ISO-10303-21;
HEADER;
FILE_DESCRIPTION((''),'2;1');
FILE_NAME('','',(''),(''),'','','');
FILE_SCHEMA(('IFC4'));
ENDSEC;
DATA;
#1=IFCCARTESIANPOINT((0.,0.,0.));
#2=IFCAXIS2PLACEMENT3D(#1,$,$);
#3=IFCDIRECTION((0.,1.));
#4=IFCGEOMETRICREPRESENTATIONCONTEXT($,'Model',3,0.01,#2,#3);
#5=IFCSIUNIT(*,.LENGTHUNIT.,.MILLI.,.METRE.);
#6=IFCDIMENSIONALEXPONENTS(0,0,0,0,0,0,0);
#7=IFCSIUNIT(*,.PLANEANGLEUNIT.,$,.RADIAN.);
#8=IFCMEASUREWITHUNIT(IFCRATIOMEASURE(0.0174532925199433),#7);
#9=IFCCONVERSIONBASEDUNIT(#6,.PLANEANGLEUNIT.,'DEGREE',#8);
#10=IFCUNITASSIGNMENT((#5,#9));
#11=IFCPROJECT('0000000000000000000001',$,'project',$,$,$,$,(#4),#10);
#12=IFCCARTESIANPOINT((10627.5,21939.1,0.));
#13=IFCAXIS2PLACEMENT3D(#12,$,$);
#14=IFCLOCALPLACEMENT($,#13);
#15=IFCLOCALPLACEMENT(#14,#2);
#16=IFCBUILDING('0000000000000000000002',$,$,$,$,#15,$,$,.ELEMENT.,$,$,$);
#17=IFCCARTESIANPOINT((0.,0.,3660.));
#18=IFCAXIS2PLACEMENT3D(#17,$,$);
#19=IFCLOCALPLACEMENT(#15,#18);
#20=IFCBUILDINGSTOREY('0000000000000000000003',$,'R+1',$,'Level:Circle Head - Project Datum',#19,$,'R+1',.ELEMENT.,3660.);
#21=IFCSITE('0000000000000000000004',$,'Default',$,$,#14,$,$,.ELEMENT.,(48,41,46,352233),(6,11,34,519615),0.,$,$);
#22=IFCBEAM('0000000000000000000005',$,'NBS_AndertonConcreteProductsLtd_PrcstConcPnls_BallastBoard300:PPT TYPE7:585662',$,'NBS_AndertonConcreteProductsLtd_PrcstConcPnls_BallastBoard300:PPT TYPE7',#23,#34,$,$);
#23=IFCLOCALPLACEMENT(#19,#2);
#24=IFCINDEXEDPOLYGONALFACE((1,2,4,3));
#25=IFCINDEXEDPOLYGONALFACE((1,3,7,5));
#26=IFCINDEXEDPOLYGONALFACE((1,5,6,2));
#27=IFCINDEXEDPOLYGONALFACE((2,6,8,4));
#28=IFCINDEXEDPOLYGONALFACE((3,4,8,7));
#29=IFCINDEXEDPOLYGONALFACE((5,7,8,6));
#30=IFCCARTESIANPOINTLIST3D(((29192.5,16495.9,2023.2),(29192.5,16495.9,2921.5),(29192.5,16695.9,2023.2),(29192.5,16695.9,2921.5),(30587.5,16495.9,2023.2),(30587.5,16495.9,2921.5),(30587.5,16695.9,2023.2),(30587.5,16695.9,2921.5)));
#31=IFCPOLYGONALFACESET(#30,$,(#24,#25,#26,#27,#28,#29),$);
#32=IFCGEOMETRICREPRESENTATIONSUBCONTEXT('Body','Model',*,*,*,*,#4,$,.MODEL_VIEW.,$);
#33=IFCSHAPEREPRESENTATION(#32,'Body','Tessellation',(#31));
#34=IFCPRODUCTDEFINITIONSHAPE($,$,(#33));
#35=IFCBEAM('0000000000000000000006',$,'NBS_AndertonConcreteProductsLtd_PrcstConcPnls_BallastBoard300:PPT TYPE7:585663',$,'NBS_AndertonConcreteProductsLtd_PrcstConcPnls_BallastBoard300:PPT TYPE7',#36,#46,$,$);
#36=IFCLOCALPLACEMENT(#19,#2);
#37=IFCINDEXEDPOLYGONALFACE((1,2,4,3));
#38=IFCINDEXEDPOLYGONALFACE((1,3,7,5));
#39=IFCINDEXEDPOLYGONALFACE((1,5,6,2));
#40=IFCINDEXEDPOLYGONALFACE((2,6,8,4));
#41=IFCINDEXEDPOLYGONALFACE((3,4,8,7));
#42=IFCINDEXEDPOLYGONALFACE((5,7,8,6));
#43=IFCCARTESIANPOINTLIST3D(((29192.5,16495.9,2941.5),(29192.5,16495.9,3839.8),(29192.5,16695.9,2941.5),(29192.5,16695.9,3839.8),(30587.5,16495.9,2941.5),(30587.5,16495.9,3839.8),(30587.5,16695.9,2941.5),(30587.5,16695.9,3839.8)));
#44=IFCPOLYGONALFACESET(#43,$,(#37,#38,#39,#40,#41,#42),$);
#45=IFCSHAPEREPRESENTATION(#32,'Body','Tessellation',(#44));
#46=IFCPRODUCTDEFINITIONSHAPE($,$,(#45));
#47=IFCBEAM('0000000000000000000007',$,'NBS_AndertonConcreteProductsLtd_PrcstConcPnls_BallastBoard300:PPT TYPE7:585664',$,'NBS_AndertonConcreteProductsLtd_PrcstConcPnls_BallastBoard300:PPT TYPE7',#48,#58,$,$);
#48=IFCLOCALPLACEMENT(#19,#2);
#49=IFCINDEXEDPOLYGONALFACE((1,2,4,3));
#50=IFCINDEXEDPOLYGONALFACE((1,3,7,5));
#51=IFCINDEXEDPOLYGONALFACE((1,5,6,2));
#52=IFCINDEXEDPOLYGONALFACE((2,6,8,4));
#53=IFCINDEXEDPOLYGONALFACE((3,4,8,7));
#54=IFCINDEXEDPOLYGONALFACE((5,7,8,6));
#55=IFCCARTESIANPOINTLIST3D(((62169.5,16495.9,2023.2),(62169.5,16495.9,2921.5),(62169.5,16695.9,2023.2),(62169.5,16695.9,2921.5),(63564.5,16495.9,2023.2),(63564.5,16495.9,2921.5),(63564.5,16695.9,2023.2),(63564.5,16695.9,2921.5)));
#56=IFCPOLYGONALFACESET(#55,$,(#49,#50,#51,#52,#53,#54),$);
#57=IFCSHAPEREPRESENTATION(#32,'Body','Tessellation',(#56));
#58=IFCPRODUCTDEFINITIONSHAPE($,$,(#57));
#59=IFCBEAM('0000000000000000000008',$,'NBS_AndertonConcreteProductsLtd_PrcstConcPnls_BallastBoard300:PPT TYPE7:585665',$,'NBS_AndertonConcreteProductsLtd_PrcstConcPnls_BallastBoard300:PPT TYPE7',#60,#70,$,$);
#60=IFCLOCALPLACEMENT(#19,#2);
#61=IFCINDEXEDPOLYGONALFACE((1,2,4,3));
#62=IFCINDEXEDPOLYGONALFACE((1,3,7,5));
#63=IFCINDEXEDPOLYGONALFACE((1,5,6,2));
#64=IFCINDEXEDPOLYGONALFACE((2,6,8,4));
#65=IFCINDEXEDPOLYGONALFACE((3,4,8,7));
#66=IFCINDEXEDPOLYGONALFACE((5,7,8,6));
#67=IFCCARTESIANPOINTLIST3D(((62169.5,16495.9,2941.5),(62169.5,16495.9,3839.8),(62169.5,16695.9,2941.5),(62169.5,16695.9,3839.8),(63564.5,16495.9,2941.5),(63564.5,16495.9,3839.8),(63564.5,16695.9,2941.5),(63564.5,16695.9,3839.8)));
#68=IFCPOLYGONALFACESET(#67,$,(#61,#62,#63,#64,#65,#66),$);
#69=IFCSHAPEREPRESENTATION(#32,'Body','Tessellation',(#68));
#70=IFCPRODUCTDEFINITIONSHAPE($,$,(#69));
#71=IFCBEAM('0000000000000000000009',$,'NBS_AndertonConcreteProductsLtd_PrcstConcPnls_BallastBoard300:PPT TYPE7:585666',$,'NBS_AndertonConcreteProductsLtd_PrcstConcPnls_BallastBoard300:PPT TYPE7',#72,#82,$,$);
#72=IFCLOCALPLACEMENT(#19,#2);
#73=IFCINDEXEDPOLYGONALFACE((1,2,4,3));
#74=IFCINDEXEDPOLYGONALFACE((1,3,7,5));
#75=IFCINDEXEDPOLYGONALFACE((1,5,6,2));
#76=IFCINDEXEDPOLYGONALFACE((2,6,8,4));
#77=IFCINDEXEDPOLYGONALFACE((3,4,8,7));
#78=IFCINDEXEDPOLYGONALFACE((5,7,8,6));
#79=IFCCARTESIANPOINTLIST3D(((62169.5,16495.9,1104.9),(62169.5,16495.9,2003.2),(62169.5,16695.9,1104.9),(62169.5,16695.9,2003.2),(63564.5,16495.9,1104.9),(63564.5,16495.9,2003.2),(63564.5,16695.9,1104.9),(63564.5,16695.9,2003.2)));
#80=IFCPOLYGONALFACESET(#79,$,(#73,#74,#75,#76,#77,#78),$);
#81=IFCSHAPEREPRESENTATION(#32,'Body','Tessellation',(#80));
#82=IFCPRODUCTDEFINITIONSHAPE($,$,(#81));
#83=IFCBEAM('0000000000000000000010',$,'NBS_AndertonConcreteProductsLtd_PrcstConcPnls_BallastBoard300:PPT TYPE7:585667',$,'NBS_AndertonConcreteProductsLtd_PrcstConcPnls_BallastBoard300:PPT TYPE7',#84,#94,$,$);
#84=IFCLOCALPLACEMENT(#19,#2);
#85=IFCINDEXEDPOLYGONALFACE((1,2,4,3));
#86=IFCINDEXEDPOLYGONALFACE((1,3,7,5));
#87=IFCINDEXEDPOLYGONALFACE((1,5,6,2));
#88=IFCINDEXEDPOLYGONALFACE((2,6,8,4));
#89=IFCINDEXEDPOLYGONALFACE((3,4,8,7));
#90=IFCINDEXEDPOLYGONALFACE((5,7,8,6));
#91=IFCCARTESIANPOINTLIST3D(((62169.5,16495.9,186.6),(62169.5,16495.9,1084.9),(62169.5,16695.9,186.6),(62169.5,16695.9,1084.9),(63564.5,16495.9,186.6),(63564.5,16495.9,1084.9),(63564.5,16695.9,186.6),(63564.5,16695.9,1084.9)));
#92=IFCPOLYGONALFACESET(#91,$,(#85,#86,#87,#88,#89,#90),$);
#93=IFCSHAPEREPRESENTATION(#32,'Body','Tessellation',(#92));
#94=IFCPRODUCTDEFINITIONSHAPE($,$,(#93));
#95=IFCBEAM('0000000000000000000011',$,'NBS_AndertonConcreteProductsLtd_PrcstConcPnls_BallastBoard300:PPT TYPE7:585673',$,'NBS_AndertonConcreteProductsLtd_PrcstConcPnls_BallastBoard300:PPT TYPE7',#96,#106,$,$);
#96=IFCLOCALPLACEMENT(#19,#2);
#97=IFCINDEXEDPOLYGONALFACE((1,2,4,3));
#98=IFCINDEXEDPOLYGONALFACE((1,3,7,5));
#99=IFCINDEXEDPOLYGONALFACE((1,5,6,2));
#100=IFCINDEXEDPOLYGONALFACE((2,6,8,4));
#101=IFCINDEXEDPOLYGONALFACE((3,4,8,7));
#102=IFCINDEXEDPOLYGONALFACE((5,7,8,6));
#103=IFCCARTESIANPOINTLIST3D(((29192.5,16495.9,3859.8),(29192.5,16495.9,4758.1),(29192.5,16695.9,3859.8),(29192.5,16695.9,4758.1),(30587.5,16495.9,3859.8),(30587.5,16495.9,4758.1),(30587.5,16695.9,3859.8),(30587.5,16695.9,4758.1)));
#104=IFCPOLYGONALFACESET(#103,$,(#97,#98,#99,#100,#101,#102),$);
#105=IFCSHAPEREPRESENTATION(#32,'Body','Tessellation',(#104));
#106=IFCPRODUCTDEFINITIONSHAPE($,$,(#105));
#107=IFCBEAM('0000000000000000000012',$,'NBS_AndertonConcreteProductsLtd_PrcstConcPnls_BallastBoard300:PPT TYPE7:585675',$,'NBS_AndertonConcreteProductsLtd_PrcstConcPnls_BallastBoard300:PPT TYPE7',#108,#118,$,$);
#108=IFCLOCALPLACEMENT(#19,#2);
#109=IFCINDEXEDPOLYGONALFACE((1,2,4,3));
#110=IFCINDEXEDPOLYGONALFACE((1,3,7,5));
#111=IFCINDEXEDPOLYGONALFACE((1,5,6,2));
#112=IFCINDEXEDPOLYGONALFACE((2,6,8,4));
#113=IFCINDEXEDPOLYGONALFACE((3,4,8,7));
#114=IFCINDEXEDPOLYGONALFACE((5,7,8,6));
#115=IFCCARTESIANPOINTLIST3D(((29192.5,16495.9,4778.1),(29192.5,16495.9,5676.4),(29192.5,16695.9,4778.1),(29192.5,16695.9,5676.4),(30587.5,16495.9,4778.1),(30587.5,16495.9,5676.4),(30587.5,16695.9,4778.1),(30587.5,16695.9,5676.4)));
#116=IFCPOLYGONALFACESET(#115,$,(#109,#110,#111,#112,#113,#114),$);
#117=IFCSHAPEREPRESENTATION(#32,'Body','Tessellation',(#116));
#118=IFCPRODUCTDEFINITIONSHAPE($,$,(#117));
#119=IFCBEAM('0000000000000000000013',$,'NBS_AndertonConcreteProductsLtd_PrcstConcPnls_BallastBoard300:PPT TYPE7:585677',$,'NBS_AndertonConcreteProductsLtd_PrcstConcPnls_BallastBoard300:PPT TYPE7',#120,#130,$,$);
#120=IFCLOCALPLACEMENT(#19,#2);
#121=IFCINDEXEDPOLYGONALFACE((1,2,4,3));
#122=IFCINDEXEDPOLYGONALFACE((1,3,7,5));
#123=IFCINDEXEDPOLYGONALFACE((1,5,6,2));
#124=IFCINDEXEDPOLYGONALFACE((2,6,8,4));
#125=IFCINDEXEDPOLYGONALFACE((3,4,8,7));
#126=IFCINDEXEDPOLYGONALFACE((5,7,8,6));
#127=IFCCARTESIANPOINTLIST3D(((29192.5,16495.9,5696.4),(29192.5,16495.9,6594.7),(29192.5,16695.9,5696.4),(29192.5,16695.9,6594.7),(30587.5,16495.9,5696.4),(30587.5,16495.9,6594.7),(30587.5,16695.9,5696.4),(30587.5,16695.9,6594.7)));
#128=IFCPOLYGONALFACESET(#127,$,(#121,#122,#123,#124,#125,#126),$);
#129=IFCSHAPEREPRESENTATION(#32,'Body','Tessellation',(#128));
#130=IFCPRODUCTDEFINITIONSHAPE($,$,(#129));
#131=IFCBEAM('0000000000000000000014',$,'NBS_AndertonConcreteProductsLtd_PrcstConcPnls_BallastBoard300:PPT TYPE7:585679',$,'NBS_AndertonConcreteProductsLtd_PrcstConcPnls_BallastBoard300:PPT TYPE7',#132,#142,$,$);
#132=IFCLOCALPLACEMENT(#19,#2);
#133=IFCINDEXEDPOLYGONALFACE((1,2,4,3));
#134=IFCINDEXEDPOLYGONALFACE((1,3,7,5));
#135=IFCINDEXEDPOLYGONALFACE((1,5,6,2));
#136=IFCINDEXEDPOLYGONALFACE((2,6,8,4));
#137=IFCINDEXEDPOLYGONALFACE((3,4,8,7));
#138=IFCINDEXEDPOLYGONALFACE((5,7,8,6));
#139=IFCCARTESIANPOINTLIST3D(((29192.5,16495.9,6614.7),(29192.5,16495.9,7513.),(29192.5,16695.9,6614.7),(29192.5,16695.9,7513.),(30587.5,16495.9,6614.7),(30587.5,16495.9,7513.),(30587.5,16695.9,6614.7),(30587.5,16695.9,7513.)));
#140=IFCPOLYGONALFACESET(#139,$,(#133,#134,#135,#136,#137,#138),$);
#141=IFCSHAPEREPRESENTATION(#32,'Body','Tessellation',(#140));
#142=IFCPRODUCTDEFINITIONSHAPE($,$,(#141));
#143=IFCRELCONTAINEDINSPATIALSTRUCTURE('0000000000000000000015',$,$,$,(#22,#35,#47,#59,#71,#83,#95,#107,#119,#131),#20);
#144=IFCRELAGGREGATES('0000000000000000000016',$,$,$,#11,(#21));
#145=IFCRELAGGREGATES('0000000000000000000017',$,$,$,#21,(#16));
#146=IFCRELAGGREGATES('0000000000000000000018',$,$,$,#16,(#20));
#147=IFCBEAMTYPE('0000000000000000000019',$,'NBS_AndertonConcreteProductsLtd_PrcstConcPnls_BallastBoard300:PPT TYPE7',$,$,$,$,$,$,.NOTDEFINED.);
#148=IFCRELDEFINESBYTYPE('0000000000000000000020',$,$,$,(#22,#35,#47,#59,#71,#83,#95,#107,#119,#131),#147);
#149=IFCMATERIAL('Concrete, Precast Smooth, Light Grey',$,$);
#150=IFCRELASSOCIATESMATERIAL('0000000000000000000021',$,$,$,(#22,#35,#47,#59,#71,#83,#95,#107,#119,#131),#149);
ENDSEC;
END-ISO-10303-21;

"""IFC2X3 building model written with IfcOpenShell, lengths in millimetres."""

from ifc_helpers import new_model, entity, si_unit, converted_unit, direction, frame, frame_2d, origin, place, context, subcontext, project, spatial, rectangle, extrude, material, type_object, element, save


model = new_model("IFC2X3")

# Units and contexts
model_context = context("Model", 3, precision=0.01, world=origin(), true_north=direction((0.0, 1.0)))
body_context = subcontext(model_context, "Body", "Model", "MODEL_VIEW")
ifc_project = project(units=[si_unit("LENGTHUNIT", "METRE", prefix="MILLI"), converted_unit("PLANEANGLEUNIT", "DEGREE", entity("IfcRatioMeasure", 0.0174532925199433), si_unit("PLANEANGLEUNIT", "RADIAN"), dimensions=[0, 0, 0, 0, 0, 0, 0])], contexts=[model_context])

# Site, building, storey
site_placement = place(None, frame((10627.5, 21939.1, 0.0)))
site = spatial("IfcSite", under=ifc_project, at=site_placement, Name="Default", CompositionType="ELEMENT", RefLatitude=(48, 41, 46, 352233), RefLongitude=(6, 11, 34, 519615), RefElevation=0.0)
building_placement = place(site_placement, origin())
building = spatial("IfcBuilding", under=site, at=building_placement, CompositionType="ELEMENT")
storey_placement = place(building_placement, frame((0.0, 0.0, 3660.0)))
storey = spatial("IfcBuildingStorey", under=building, at=storey_placement, Name="R+1", ObjectType="Level:Circle Head - Project Datum", LongName="R+1", CompositionType="ELEMENT", Elevation=3660.0)

# Shared definitions
ifc_material_1 = material(Name="Concrete, Precast Smooth, Light Grey")

# Beams
beam_type_1 = type_object("IfcBeamType", Name="NBS_AndertonConcreteProductsLtd_PrcstConcPnls_BallastBoard300:PPT TYPE7", PredefinedType="NOTDEFINED")
beam_1_placement = place(storey_placement, origin())
element("IfcBeam", 1, at=beam_1_placement, inside=storey, type_object=beam_type_1, material=ifc_material_1, Name="NBS_AndertonConcreteProductsLtd_PrcstConcPnls_BallastBoard300:PPT TYPE7:585662", ObjectType="NBS_AndertonConcreteProductsLtd_PrcstConcPnls_BallastBoard300:PPT TYPE7", context=body_context, shape_type="SweptSolid", body=[
    extrude(rectangle(XDim=898.3, YDim=200.0, at=frame_2d((0.0, 0.0), x_axis=(1.0, 0.0))), frame((29192.5, 16595.9, 2472.4), z_axis=(1.0, 0.0, 0.0), x_axis=(0.0, 0.0, -1.0)), (0.0, 0.0, 1.0), 1395.0),
])
beam_2_placement = place(storey_placement, origin())
element("IfcBeam", 2, at=beam_2_placement, inside=storey, type_object=beam_type_1, material=ifc_material_1, Name="NBS_AndertonConcreteProductsLtd_PrcstConcPnls_BallastBoard300:PPT TYPE7:585663", ObjectType="NBS_AndertonConcreteProductsLtd_PrcstConcPnls_BallastBoard300:PPT TYPE7", context=body_context, shape_type="SweptSolid", body=[
    extrude(rectangle(XDim=898.3, YDim=200.0, at=frame_2d((0.0, 0.0), x_axis=(1.0, 0.0))), frame((29192.5, 16595.9, 3390.7), z_axis=(1.0, 0.0, 0.0), x_axis=(0.0, 0.0, -1.0)), (0.0, 0.0, 1.0), 1395.0),
])
beam_3_placement = place(storey_placement, origin())
element("IfcBeam", 3, at=beam_3_placement, inside=storey, type_object=beam_type_1, material=ifc_material_1, Name="NBS_AndertonConcreteProductsLtd_PrcstConcPnls_BallastBoard300:PPT TYPE7:585664", ObjectType="NBS_AndertonConcreteProductsLtd_PrcstConcPnls_BallastBoard300:PPT TYPE7", context=body_context, shape_type="SweptSolid", body=[
    extrude(rectangle(XDim=898.3, YDim=200.0, at=frame_2d((0.0, 0.0), x_axis=(1.0, 0.0))), frame((62169.5, 16595.9, 2472.4), z_axis=(1.0, 0.0, 0.0), x_axis=(0.0, 0.0, -1.0)), (0.0, 0.0, 1.0), 1395.0),
])
beam_4_placement = place(storey_placement, origin())
element("IfcBeam", 4, at=beam_4_placement, inside=storey, type_object=beam_type_1, material=ifc_material_1, Name="NBS_AndertonConcreteProductsLtd_PrcstConcPnls_BallastBoard300:PPT TYPE7:585665", ObjectType="NBS_AndertonConcreteProductsLtd_PrcstConcPnls_BallastBoard300:PPT TYPE7", context=body_context, shape_type="SweptSolid", body=[
    extrude(rectangle(XDim=898.3, YDim=200.0, at=frame_2d((0.0, 0.0), x_axis=(1.0, 0.0))), frame((62169.5, 16595.9, 3390.7), z_axis=(1.0, 0.0, 0.0), x_axis=(0.0, 0.0, -1.0)), (0.0, 0.0, 1.0), 1395.0),
])
beam_5_placement = place(storey_placement, origin())
element("IfcBeam", 5, at=beam_5_placement, inside=storey, type_object=beam_type_1, material=ifc_material_1, Name="NBS_AndertonConcreteProductsLtd_PrcstConcPnls_BallastBoard300:PPT TYPE7:585666", ObjectType="NBS_AndertonConcreteProductsLtd_PrcstConcPnls_BallastBoard300:PPT TYPE7", context=body_context, shape_type="SweptSolid", body=[
    extrude(rectangle(XDim=898.3, YDim=200.0, at=frame_2d((0.0, 0.0), x_axis=(1.0, 0.0))), frame((62169.5, 16595.9, 1554.0), z_axis=(1.0, 0.0, 0.0), x_axis=(0.0, 0.0, -1.0)), (0.0, 0.0, 1.0), 1395.0),
])
beam_6_placement = place(storey_placement, origin())
element("IfcBeam", 6, at=beam_6_placement, inside=storey, type_object=beam_type_1, material=ifc_material_1, Name="NBS_AndertonConcreteProductsLtd_PrcstConcPnls_BallastBoard300:PPT TYPE7:585667", ObjectType="NBS_AndertonConcreteProductsLtd_PrcstConcPnls_BallastBoard300:PPT TYPE7", context=body_context, shape_type="SweptSolid", body=[
    extrude(rectangle(XDim=898.3, YDim=200.0, at=frame_2d((0.0, 0.0), x_axis=(1.0, 0.0))), frame((62169.5, 16595.9, 635.7), z_axis=(1.0, 0.0, 0.0), x_axis=(0.0, 0.0, -1.0)), (0.0, 0.0, 1.0), 1395.0),
])
beam_7_placement = place(storey_placement, origin())
element("IfcBeam", 7, at=beam_7_placement, inside=storey, type_object=beam_type_1, material=ifc_material_1, Name="NBS_AndertonConcreteProductsLtd_PrcstConcPnls_BallastBoard300:PPT TYPE7:585673", ObjectType="NBS_AndertonConcreteProductsLtd_PrcstConcPnls_BallastBoard300:PPT TYPE7", context=body_context, shape_type="SweptSolid", body=[
    extrude(rectangle(XDim=898.3, YDim=200.0, at=frame_2d((0.0, 0.0), x_axis=(1.0, 0.0))), frame((29192.5, 16595.9, 4309.0), z_axis=(1.0, 0.0, 0.0), x_axis=(0.0, 0.0, -1.0)), (0.0, 0.0, 1.0), 1395.0),
])
beam_8_placement = place(storey_placement, origin())
element("IfcBeam", 8, at=beam_8_placement, inside=storey, type_object=beam_type_1, material=ifc_material_1, Name="NBS_AndertonConcreteProductsLtd_PrcstConcPnls_BallastBoard300:PPT TYPE7:585675", ObjectType="NBS_AndertonConcreteProductsLtd_PrcstConcPnls_BallastBoard300:PPT TYPE7", context=body_context, shape_type="SweptSolid", body=[
    extrude(rectangle(XDim=898.3, YDim=200.0, at=frame_2d((0.0, 0.0), x_axis=(1.0, 0.0))), frame((29192.5, 16595.9, 5227.3), z_axis=(1.0, 0.0, 0.0), x_axis=(0.0, 0.0, -1.0)), (0.0, 0.0, 1.0), 1395.0),
])
beam_9_placement = place(storey_placement, origin())
element("IfcBeam", 9, at=beam_9_placement, inside=storey, type_object=beam_type_1, material=ifc_material_1, Name="NBS_AndertonConcreteProductsLtd_PrcstConcPnls_BallastBoard300:PPT TYPE7:585677", ObjectType="NBS_AndertonConcreteProductsLtd_PrcstConcPnls_BallastBoard300:PPT TYPE7", context=body_context, shape_type="SweptSolid", body=[
    extrude(rectangle(XDim=898.3, YDim=200.0, at=frame_2d((0.0, 0.0), x_axis=(1.0, 0.0))), frame((29192.5, 16595.9, 6145.6), z_axis=(1.0, 0.0, 0.0), x_axis=(0.0, 0.0, -1.0)), (0.0, 0.0, 1.0), 1395.0),
])
beam_10_placement = place(storey_placement, origin())
element("IfcBeam", 10, at=beam_10_placement, inside=storey, type_object=beam_type_1, material=ifc_material_1, Name="NBS_AndertonConcreteProductsLtd_PrcstConcPnls_BallastBoard300:PPT TYPE7:585679", ObjectType="NBS_AndertonConcreteProductsLtd_PrcstConcPnls_BallastBoard300:PPT TYPE7", context=body_context, shape_type="SweptSolid", body=[
    extrude(rectangle(XDim=898.3, YDim=200.0, at=frame_2d((0.0, 0.0), x_axis=(1.0, 0.0))), frame((29192.5, 16595.9, 7063.9), z_axis=(1.0, 0.0, 0.0), x_axis=(0.0, 0.0, -1.0)), (0.0, 0.0, 1.0), 1395.0),
])

save(model, "model.ifc")
